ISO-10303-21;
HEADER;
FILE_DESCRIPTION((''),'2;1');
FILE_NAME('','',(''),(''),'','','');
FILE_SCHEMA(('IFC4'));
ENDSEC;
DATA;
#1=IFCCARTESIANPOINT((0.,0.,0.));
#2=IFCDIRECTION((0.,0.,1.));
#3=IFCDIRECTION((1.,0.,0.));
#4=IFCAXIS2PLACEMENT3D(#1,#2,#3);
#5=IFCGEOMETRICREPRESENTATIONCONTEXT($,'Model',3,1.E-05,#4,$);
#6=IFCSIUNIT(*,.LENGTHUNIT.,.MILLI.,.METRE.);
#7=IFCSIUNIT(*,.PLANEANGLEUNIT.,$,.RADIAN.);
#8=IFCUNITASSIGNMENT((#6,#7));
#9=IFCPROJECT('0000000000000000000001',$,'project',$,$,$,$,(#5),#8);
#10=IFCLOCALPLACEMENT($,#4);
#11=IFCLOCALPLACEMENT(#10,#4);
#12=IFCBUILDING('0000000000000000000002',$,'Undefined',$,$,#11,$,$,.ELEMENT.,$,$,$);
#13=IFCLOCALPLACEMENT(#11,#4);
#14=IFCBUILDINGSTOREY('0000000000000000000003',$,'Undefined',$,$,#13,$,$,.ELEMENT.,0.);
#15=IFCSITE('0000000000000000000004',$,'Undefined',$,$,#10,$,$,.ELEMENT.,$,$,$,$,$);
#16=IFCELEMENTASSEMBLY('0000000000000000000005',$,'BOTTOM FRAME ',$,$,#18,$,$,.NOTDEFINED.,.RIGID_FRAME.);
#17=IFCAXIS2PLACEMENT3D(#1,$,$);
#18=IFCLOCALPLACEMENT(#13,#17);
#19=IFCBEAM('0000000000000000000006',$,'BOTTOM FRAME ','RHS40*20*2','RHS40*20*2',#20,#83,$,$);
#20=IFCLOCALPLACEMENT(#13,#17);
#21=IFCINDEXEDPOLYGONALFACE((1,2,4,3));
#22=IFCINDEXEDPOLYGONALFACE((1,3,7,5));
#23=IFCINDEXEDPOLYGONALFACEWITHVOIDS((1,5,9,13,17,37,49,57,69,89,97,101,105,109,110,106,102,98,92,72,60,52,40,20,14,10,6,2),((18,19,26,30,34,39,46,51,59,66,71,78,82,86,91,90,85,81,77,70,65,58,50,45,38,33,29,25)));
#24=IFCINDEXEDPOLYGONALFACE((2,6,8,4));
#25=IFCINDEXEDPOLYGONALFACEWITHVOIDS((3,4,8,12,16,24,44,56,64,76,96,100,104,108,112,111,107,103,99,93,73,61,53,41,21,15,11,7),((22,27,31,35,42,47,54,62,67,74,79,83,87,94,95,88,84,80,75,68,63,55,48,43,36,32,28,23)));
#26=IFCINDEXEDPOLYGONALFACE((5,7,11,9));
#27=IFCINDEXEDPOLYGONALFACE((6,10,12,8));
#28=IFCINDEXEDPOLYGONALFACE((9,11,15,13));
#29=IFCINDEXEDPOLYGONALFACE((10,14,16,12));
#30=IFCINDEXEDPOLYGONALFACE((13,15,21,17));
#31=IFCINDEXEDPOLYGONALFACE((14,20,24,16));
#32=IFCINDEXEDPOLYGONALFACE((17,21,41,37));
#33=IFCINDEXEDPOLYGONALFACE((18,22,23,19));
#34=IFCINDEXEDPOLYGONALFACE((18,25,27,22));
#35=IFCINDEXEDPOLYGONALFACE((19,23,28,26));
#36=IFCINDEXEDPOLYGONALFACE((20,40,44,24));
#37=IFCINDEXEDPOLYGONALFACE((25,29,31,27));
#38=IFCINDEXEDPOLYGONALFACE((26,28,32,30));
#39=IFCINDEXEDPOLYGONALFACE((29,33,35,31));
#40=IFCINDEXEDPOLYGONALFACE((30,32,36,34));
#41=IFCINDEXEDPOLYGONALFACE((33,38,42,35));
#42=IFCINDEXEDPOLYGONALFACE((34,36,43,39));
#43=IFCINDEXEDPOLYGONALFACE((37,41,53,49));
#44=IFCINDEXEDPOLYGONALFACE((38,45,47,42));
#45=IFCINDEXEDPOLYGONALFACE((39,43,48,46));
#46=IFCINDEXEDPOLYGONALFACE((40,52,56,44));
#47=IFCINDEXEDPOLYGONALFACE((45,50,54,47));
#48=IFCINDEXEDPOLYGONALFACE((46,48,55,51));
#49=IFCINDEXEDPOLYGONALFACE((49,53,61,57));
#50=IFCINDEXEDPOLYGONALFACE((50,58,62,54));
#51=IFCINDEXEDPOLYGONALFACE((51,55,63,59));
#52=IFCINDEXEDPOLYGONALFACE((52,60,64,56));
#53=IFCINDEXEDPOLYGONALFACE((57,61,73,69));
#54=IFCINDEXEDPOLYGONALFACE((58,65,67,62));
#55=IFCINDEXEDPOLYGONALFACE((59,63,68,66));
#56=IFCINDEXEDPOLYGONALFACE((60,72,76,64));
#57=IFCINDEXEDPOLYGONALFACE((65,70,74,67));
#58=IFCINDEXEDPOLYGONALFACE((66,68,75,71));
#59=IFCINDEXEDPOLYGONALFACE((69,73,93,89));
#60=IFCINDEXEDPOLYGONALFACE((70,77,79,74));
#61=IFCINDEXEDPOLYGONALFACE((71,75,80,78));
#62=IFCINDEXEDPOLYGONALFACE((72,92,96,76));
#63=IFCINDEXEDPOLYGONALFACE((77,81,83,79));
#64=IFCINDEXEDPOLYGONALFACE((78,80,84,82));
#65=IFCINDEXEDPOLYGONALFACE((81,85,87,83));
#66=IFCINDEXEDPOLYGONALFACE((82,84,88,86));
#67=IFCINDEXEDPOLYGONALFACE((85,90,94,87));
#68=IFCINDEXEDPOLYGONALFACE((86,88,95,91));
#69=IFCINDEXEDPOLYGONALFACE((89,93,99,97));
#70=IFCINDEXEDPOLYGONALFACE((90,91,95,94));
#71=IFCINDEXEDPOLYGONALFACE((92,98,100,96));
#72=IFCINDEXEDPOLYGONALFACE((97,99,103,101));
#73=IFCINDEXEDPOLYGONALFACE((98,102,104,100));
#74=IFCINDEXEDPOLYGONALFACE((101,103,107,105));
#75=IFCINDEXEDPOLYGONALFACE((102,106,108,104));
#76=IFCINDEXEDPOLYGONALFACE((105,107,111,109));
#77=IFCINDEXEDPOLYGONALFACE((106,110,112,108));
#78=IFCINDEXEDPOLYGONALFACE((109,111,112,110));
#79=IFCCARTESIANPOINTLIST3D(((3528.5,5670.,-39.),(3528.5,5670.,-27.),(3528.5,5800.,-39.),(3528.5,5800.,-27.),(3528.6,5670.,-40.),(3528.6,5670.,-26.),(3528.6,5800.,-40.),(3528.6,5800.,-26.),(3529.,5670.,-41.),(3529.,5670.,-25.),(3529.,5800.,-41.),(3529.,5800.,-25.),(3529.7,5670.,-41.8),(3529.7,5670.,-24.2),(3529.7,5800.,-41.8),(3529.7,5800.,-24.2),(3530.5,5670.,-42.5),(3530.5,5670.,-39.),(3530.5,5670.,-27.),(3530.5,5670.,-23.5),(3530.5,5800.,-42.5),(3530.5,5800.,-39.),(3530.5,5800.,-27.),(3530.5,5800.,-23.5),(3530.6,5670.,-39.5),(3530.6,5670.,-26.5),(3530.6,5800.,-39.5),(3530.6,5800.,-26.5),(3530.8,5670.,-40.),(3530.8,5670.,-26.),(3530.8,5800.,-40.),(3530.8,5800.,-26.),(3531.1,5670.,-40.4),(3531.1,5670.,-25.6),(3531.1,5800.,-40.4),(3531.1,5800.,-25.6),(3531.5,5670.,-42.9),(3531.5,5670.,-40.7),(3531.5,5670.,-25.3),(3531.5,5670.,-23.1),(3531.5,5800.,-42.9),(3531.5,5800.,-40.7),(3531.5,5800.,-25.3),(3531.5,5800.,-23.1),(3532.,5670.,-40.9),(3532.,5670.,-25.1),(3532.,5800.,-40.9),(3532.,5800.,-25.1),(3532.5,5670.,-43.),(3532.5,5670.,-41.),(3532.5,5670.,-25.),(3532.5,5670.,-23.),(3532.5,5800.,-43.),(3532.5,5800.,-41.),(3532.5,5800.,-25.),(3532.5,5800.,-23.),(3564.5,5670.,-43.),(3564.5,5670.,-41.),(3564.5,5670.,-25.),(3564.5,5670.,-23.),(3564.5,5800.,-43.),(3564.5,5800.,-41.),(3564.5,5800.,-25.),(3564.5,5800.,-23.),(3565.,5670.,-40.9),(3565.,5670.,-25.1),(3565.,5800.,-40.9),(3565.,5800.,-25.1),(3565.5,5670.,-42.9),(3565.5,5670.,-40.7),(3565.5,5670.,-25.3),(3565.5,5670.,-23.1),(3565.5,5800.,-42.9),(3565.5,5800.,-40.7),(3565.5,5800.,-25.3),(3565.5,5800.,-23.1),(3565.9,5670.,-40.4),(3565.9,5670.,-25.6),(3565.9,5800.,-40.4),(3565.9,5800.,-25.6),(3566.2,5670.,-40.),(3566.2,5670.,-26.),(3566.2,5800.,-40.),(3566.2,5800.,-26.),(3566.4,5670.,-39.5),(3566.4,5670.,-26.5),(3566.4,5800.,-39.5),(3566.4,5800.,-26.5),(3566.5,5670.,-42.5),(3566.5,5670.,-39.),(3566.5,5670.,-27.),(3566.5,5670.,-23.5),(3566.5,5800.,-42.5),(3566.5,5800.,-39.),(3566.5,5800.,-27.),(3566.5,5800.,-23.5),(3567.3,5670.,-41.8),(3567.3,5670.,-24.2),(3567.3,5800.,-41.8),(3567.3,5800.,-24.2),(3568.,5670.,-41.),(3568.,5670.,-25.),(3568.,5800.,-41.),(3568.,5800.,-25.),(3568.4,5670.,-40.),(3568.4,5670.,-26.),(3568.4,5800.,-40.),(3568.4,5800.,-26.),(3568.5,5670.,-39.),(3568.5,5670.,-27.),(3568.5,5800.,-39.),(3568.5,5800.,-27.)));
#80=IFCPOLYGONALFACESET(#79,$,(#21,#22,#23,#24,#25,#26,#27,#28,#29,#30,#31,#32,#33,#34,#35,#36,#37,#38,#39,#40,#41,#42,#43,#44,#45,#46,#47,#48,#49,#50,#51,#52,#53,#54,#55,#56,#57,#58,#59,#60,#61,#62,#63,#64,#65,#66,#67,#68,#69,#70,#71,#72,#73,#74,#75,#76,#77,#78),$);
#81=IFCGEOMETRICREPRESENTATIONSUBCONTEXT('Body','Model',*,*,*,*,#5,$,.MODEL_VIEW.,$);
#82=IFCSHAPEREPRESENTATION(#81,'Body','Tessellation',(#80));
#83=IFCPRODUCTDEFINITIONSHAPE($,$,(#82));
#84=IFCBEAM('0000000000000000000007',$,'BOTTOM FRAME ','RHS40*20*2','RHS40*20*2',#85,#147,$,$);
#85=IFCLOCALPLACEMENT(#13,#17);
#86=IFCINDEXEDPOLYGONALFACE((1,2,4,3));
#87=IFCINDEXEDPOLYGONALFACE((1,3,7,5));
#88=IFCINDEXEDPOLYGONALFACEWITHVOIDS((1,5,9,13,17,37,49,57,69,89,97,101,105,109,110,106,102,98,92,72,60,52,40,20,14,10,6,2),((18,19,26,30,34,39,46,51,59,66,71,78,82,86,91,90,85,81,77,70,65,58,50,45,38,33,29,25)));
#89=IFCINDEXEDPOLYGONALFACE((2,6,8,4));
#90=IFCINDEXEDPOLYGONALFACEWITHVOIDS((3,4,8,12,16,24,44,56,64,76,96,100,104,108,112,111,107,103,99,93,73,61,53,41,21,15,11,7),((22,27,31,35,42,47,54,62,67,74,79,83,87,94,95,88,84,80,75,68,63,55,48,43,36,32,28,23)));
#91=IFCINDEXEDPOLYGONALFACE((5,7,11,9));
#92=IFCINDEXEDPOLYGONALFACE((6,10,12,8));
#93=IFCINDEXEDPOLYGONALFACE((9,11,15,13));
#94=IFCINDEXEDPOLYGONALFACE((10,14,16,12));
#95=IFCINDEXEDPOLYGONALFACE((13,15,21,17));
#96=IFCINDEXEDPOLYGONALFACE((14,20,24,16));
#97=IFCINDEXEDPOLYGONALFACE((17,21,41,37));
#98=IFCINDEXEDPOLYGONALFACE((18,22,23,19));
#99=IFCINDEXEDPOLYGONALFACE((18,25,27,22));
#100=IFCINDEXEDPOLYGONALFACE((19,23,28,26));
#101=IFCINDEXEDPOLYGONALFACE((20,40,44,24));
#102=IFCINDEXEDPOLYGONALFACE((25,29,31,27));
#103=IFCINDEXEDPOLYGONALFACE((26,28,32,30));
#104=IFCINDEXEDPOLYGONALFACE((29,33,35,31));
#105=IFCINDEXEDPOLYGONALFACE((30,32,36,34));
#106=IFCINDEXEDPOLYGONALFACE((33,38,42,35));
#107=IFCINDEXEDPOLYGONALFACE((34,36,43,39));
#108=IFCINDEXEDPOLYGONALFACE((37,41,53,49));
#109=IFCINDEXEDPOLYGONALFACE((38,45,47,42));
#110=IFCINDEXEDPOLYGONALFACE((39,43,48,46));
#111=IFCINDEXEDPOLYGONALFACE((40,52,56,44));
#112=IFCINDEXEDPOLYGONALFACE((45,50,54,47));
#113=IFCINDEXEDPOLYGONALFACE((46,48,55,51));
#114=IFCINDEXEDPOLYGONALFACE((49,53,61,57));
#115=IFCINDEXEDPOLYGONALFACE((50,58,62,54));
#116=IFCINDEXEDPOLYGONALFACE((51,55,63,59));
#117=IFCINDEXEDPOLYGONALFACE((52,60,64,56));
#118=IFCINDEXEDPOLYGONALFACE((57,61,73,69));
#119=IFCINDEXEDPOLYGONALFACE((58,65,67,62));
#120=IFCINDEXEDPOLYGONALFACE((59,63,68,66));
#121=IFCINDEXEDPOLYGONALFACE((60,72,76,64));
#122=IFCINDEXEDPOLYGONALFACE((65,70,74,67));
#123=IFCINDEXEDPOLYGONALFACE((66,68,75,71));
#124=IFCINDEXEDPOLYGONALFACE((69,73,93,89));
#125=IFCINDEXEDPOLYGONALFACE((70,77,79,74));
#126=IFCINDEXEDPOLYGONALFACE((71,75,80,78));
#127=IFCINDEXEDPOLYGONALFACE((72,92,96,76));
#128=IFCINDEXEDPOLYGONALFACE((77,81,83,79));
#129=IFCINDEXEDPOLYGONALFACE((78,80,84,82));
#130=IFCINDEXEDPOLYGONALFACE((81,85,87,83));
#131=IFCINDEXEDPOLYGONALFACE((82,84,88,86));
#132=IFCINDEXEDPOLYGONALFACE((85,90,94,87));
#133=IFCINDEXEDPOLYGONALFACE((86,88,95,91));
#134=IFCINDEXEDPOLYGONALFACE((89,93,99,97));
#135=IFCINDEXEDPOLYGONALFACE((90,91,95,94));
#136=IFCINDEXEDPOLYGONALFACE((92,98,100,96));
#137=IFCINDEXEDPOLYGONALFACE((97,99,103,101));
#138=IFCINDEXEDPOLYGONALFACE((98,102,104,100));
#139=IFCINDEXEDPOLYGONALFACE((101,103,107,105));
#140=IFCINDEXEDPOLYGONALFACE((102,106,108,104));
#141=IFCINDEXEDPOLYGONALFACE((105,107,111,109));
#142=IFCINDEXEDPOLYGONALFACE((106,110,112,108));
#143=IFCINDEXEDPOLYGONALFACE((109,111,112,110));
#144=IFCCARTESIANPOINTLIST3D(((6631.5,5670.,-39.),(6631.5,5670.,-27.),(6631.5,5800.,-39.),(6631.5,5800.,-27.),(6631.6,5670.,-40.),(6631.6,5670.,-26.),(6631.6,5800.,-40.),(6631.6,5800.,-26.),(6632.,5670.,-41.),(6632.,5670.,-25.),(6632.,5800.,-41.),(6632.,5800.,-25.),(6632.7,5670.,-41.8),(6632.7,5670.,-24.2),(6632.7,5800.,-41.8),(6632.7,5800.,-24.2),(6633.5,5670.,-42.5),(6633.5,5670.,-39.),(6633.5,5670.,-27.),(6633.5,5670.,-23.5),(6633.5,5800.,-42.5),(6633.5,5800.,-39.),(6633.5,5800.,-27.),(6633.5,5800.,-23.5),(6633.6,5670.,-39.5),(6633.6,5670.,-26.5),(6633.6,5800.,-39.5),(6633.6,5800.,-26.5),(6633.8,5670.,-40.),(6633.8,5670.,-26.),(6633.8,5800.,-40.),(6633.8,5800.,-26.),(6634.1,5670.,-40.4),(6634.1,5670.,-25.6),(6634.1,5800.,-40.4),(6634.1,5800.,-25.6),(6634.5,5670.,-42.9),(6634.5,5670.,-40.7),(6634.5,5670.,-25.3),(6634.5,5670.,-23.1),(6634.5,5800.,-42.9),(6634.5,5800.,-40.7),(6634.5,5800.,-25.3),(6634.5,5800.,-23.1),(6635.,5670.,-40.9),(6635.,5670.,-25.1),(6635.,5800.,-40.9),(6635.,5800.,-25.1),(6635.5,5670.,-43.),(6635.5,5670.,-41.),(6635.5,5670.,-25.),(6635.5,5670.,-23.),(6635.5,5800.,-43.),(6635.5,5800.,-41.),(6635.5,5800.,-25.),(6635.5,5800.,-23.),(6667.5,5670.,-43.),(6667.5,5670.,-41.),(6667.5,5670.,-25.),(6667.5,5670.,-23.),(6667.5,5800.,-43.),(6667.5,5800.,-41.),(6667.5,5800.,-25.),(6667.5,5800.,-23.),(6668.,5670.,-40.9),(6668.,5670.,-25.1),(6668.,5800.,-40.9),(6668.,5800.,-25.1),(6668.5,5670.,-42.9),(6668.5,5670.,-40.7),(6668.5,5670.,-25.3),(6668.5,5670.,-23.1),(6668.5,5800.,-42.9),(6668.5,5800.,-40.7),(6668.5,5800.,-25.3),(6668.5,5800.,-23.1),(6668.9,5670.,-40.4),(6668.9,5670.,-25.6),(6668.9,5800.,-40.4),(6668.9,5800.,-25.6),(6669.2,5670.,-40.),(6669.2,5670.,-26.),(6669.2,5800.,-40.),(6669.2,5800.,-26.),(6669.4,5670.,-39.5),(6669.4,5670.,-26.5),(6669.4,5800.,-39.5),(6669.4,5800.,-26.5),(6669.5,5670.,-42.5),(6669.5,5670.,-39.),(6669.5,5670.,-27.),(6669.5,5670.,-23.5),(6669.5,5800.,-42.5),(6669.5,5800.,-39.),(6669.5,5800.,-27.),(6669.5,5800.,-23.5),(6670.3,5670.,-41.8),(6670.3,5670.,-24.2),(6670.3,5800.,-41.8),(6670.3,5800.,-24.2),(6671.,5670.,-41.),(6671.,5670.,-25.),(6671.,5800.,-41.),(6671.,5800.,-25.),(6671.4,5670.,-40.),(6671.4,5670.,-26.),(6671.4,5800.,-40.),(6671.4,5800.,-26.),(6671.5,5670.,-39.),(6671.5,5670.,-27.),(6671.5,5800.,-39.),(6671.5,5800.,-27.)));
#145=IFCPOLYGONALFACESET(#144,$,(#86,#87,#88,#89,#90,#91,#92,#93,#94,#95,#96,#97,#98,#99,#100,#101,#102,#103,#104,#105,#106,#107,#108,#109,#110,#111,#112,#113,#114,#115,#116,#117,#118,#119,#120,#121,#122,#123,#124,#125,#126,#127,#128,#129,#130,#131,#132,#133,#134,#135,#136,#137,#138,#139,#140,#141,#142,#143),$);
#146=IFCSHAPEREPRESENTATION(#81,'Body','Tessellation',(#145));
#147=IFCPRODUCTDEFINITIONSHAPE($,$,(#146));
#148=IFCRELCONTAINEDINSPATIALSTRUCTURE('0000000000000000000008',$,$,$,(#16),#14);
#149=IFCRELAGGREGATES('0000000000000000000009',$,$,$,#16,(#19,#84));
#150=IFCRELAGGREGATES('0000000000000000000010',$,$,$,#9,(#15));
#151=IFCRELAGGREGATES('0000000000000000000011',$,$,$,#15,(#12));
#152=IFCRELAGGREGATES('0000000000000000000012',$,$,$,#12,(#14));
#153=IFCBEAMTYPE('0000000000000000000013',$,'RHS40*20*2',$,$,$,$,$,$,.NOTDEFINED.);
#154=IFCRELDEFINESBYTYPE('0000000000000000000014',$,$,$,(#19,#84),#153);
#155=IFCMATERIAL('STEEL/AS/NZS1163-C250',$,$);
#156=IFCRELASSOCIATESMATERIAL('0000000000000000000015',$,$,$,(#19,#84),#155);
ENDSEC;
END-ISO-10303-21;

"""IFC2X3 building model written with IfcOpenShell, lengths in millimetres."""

from ifc_helpers import new_model, si_unit, frame, origin_with_axes, origin_2d_with_axis, place, context, subcontext, project, spatial, hollow_rectangle, extrude, material, type_object, element, aggregate, save


model = new_model("IFC2X3")

# Units and contexts
model_context = context("Model", 3, precision=1e-05, world=origin_with_axes())
body_context = subcontext(model_context, "Body", "Model", "MODEL_VIEW")
ifc_project = project(units=[si_unit("LENGTHUNIT", "METRE", prefix="MILLI"), si_unit("PLANEANGLEUNIT", "RADIAN")], contexts=[model_context])

# Site, building, storey
site_placement = place(None, origin_with_axes())
site = spatial("IfcSite", under=ifc_project, at=site_placement, Name="Undefined", CompositionType="ELEMENT")
building_placement = place(site_placement, origin_with_axes())
building = spatial("IfcBuilding", under=site, at=building_placement, Name="Undefined", CompositionType="ELEMENT")
storey_placement = place(building_placement, origin_with_axes())
storey = spatial("IfcBuildingStorey", under=building, at=storey_placement, Name="Undefined", CompositionType="ELEMENT", Elevation=0.0)

# Element assembly, beams
assembly_1_placement = place(storey_placement, origin_with_axes())
assembly_1 = element("IfcElementAssembly", 1, at=assembly_1_placement, inside=storey, Name="BOTTOM FRAME ", AssemblyPlace="NOTDEFINED", PredefinedType="RIGID_FRAME")
ifc_material_1 = material(Name="STEEL/AS/NZS1163-C250")
beam_type_1 = type_object("IfcBeamType", Name="RHS40*20*2", PredefinedType="NOTDEFINED")
beam_1_placement = place(assembly_1_placement, frame((3548.5, 5800.0, -33.0), z_axis=(1.0, 0.0, 0.0), x_axis=(0.0, -1.0, 0.0)))
beam_1 = element("IfcBeam", 2, at=beam_1_placement, type_object=beam_type_1, material=ifc_material_1, Name="BOTTOM FRAME ", Description="RHS40*20*2", ObjectType="RHS40*20*2", context=body_context, shape_type="SweptSolid", body=[
    extrude(hollow_rectangle(XDim=20.0, YDim=40.0, WallThickness=2.0, InnerFilletRadius=2.0, OuterFilletRadius=4.0, at=origin_2d_with_axis()), frame((130.0, 0.0, 0.0), z_axis=(-1.0, 0.0, 0.0), x_axis=(0.0, -1.0, 0.0)), (0.0, 0.0, 1.0), 130.0),
])
beam_2_placement = place(assembly_1_placement, frame((6651.5, 5800.0, -33.0), z_axis=(-1.0, 0.0, 0.0), x_axis=(0.0, -1.0, 0.0)))
beam_2 = element("IfcBeam", 3, at=beam_2_placement, type_object=beam_type_1, material=ifc_material_1, Name="BOTTOM FRAME ", Description="RHS40*20*2", ObjectType="RHS40*20*2", context=body_context, shape_type="SweptSolid", body=[
    extrude(hollow_rectangle(XDim=20.0, YDim=40.0, WallThickness=2.0, InnerFilletRadius=2.0, OuterFilletRadius=4.0, at=origin_2d_with_axis()), frame((130.0, 0.0, 0.0), z_axis=(-1.0, 0.0, 0.0), x_axis=(0.0, -1.0, 0.0)), (0.0, 0.0, 1.0), 130.0),
])

aggregate(assembly_1, [beam_1, beam_2])

save(model, "model.ifc")
